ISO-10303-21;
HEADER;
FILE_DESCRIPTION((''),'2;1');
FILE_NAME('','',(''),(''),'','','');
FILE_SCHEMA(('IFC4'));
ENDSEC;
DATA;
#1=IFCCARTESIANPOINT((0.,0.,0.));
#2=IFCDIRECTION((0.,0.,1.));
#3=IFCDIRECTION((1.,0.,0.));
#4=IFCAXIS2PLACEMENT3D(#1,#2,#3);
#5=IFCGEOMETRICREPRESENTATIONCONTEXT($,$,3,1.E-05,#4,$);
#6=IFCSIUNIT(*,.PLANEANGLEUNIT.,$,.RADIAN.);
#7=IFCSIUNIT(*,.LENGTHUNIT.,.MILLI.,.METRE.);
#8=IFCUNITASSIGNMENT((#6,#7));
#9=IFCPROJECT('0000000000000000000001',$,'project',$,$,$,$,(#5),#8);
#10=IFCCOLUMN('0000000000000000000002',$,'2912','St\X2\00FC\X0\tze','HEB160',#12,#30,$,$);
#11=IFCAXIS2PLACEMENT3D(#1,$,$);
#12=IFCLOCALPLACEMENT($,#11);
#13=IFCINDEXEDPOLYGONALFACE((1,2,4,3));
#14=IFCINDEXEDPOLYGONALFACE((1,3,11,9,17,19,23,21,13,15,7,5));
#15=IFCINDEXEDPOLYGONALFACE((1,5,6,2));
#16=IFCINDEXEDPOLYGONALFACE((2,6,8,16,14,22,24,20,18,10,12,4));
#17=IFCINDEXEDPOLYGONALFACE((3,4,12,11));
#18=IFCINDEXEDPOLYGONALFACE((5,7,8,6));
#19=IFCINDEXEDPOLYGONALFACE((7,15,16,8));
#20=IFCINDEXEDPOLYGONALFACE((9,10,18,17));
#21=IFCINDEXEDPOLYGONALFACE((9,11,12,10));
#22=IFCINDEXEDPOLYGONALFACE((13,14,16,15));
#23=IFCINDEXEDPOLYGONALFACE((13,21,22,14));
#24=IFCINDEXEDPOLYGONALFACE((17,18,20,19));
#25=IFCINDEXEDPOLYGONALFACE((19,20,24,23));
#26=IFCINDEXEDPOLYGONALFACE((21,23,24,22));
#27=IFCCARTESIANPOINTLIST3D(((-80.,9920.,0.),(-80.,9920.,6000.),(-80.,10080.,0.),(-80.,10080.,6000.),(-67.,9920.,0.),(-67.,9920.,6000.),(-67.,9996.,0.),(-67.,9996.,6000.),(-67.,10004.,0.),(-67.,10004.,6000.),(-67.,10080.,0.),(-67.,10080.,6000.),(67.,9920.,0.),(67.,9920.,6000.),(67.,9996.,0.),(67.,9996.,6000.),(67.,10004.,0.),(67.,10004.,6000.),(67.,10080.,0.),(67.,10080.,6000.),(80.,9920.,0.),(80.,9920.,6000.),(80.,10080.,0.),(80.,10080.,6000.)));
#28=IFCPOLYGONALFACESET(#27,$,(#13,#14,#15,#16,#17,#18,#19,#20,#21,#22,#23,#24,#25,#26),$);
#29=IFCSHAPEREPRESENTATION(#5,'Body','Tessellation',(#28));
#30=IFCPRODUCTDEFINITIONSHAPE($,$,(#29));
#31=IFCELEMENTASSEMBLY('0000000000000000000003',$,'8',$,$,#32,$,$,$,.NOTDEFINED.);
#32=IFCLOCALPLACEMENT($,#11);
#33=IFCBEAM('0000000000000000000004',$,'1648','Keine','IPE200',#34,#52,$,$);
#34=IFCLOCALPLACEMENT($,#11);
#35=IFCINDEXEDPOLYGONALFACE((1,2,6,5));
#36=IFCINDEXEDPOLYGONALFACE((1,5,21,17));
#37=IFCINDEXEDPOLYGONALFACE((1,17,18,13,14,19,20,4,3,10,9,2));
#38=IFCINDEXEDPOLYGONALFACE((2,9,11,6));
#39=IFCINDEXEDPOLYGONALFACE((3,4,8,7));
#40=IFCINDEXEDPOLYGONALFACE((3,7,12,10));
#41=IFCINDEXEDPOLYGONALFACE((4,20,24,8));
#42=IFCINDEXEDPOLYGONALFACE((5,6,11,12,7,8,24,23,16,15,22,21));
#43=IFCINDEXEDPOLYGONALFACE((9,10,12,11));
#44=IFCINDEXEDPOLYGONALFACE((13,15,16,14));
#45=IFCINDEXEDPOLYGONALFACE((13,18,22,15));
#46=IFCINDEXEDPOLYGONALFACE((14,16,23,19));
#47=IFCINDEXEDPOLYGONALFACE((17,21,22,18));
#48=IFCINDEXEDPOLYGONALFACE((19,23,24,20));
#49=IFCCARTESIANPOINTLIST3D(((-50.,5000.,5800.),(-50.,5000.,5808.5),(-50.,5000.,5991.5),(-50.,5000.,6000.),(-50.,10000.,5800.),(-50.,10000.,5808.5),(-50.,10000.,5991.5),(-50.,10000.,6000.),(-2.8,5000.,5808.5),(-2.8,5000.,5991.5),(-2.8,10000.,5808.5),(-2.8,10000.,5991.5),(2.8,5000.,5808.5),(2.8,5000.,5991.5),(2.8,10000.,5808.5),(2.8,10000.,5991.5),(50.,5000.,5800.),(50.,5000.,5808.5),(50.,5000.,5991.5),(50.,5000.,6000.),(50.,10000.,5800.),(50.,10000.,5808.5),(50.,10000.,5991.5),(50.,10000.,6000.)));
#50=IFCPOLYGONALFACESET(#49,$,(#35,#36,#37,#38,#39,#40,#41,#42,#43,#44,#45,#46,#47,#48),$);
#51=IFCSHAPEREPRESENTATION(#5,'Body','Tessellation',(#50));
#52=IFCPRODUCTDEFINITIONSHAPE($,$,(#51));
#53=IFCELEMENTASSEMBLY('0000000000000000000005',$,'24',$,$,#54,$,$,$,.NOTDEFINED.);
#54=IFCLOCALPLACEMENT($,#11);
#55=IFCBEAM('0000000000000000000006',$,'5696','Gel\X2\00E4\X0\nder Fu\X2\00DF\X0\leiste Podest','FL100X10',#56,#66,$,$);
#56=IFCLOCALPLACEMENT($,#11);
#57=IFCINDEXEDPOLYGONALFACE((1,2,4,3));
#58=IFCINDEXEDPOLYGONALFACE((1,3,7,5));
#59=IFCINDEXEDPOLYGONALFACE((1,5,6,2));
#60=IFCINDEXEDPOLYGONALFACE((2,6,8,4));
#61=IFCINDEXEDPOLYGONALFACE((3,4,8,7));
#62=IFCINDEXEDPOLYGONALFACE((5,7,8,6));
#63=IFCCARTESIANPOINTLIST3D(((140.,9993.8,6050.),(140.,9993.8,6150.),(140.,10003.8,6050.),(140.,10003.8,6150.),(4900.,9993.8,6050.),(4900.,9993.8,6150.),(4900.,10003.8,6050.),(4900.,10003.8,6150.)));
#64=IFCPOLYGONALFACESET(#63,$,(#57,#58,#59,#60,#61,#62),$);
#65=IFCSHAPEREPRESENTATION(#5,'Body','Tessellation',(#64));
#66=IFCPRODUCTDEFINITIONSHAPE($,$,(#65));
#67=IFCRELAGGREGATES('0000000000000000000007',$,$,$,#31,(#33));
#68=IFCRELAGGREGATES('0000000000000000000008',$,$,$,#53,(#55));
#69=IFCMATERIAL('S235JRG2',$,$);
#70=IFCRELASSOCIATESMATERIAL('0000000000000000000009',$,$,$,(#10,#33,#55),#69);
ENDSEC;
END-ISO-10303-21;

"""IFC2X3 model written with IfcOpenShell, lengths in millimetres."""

from ifc_helpers import new_model, si_unit, frame, origin_with_axes, place, context, project, polyline, outline, extrude, material, element, aggregate, save


model = new_model("IFC2X3")

# Units and contexts
context_of_model = context(None, 3, precision=1e-05, world=origin_with_axes())
ifc_project = project(units=[si_unit("PLANEANGLEUNIT", "RADIAN"), si_unit("LENGTHUNIT", "METRE", prefix="MILLI")], contexts=[context_of_model])

# Column
ifc_material = material(Name="S235JRG2")
placement_1 = place(None, frame((0.0, 10000.0, 6000.0), z_axis=(-1.0, 0.0, 0.0), x_axis=(0.0, 0.0, -1.0)))
column_placement = place(placement_1, origin_with_axes())
element("IfcColumn", 1, at=column_placement, material=ifc_material, Name="2912", Description="Stütze", ObjectType="HEB160", context=context_of_model, shape_type="SweptSolid", body=[
    extrude(outline(polyline([(80.0, -80.0), (80.0, -67.0), (4.0, -67.0), (4.0, 67.0), (80.0, 67.0), (80.0, 80.0), (-80.0, 80.0), (-80.0, 67.0), (-4.0, 67.0), (-4.0, -67.0), (-80.0, -67.0), (-80.0, -80.0), (80.0, -80.0), (80.0, -80.0)])), frame((0.0, 0.0, 0.0), z_axis=(1.0, 0.0, 0.0), x_axis=(0.0, 1.0, 0.0)), (0.0, 0.0, 1.0), 6000.0),
])

# Element assembly, beam
assembly_1_placement = place(None, frame((0.0, 10000.0, 6000.0), z_axis=(0.0, 0.0, 1.0), x_axis=(0.0, -1.0, 0.0)))
assembly_1 = element("IfcElementAssembly", 2, at=assembly_1_placement, Name="8", PredefinedType="NOTDEFINED")
placement_2 = place(None, frame((0.0, 10000.0, 5900.0), z_axis=(0.0, 0.0, 1.0), x_axis=(0.0, -1.0, 0.0)))
beam_1_placement = place(placement_2, origin_with_axes())
beam_1 = element("IfcBeam", 3, at=beam_1_placement, material=ifc_material, Name="1648", Description="Keine", ObjectType="IPE200", context=context_of_model, shape_type="SweptSolid", body=[
    extrude(outline(polyline([(50.0, -100.0), (50.0, -91.5), (2.8, -91.5), (2.8, 91.5), (50.0, 91.5), (50.0, 100.0), (-50.0, 100.0), (-50.0, 91.5), (-2.8, 91.5), (-2.8, -91.5), (-50.0, -91.5), (-50.0, -100.0), (50.0, -100.0), (50.0, -100.0)])), frame((0.0, 0.0, 0.0), z_axis=(1.0, 0.0, 0.0), x_axis=(0.0, 1.0, 0.0)), (0.0, 0.0, 1.0), 5000.0),
])
aggregate(assembly_1, [beam_1])

# Element assembly, beam
assembly_2_placement = place(None, frame((140.0, 9998.8, 6100.0), z_axis=(0.0, 0.0, 1.0), x_axis=(1.0, 0.0, 0.0)))
assembly_2 = element("IfcElementAssembly", 4, at=assembly_2_placement, Name="24", PredefinedType="NOTDEFINED")
placement_3 = place(None, frame((140.0, 9998.8, 6100.0), z_axis=(0.0, 0.0, 1.0), x_axis=(1.0, 0.0, 0.0)))
beam_2_placement = place(placement_3, origin_with_axes())
beam_2 = element("IfcBeam", 5, at=beam_2_placement, material=ifc_material, Name="5696", Description="Geländer Fußleiste Podest", ObjectType="FL100X10", context=context_of_model, shape_type="SweptSolid", body=[
    extrude(outline(polyline([(5.0, -50.0), (5.0, 50.0), (-5.0, 50.0), (-5.0, -50.0), (5.0, -50.0), (5.0, -50.0)])), frame((0.0, 0.0, 0.0), z_axis=(1.0, 0.0, 0.0), x_axis=(0.0, 1.0, 0.0)), (0.0, 0.0, 1.0), 4760.0),
])
aggregate(assembly_2, [beam_2])

save(model, "model.ifc")
